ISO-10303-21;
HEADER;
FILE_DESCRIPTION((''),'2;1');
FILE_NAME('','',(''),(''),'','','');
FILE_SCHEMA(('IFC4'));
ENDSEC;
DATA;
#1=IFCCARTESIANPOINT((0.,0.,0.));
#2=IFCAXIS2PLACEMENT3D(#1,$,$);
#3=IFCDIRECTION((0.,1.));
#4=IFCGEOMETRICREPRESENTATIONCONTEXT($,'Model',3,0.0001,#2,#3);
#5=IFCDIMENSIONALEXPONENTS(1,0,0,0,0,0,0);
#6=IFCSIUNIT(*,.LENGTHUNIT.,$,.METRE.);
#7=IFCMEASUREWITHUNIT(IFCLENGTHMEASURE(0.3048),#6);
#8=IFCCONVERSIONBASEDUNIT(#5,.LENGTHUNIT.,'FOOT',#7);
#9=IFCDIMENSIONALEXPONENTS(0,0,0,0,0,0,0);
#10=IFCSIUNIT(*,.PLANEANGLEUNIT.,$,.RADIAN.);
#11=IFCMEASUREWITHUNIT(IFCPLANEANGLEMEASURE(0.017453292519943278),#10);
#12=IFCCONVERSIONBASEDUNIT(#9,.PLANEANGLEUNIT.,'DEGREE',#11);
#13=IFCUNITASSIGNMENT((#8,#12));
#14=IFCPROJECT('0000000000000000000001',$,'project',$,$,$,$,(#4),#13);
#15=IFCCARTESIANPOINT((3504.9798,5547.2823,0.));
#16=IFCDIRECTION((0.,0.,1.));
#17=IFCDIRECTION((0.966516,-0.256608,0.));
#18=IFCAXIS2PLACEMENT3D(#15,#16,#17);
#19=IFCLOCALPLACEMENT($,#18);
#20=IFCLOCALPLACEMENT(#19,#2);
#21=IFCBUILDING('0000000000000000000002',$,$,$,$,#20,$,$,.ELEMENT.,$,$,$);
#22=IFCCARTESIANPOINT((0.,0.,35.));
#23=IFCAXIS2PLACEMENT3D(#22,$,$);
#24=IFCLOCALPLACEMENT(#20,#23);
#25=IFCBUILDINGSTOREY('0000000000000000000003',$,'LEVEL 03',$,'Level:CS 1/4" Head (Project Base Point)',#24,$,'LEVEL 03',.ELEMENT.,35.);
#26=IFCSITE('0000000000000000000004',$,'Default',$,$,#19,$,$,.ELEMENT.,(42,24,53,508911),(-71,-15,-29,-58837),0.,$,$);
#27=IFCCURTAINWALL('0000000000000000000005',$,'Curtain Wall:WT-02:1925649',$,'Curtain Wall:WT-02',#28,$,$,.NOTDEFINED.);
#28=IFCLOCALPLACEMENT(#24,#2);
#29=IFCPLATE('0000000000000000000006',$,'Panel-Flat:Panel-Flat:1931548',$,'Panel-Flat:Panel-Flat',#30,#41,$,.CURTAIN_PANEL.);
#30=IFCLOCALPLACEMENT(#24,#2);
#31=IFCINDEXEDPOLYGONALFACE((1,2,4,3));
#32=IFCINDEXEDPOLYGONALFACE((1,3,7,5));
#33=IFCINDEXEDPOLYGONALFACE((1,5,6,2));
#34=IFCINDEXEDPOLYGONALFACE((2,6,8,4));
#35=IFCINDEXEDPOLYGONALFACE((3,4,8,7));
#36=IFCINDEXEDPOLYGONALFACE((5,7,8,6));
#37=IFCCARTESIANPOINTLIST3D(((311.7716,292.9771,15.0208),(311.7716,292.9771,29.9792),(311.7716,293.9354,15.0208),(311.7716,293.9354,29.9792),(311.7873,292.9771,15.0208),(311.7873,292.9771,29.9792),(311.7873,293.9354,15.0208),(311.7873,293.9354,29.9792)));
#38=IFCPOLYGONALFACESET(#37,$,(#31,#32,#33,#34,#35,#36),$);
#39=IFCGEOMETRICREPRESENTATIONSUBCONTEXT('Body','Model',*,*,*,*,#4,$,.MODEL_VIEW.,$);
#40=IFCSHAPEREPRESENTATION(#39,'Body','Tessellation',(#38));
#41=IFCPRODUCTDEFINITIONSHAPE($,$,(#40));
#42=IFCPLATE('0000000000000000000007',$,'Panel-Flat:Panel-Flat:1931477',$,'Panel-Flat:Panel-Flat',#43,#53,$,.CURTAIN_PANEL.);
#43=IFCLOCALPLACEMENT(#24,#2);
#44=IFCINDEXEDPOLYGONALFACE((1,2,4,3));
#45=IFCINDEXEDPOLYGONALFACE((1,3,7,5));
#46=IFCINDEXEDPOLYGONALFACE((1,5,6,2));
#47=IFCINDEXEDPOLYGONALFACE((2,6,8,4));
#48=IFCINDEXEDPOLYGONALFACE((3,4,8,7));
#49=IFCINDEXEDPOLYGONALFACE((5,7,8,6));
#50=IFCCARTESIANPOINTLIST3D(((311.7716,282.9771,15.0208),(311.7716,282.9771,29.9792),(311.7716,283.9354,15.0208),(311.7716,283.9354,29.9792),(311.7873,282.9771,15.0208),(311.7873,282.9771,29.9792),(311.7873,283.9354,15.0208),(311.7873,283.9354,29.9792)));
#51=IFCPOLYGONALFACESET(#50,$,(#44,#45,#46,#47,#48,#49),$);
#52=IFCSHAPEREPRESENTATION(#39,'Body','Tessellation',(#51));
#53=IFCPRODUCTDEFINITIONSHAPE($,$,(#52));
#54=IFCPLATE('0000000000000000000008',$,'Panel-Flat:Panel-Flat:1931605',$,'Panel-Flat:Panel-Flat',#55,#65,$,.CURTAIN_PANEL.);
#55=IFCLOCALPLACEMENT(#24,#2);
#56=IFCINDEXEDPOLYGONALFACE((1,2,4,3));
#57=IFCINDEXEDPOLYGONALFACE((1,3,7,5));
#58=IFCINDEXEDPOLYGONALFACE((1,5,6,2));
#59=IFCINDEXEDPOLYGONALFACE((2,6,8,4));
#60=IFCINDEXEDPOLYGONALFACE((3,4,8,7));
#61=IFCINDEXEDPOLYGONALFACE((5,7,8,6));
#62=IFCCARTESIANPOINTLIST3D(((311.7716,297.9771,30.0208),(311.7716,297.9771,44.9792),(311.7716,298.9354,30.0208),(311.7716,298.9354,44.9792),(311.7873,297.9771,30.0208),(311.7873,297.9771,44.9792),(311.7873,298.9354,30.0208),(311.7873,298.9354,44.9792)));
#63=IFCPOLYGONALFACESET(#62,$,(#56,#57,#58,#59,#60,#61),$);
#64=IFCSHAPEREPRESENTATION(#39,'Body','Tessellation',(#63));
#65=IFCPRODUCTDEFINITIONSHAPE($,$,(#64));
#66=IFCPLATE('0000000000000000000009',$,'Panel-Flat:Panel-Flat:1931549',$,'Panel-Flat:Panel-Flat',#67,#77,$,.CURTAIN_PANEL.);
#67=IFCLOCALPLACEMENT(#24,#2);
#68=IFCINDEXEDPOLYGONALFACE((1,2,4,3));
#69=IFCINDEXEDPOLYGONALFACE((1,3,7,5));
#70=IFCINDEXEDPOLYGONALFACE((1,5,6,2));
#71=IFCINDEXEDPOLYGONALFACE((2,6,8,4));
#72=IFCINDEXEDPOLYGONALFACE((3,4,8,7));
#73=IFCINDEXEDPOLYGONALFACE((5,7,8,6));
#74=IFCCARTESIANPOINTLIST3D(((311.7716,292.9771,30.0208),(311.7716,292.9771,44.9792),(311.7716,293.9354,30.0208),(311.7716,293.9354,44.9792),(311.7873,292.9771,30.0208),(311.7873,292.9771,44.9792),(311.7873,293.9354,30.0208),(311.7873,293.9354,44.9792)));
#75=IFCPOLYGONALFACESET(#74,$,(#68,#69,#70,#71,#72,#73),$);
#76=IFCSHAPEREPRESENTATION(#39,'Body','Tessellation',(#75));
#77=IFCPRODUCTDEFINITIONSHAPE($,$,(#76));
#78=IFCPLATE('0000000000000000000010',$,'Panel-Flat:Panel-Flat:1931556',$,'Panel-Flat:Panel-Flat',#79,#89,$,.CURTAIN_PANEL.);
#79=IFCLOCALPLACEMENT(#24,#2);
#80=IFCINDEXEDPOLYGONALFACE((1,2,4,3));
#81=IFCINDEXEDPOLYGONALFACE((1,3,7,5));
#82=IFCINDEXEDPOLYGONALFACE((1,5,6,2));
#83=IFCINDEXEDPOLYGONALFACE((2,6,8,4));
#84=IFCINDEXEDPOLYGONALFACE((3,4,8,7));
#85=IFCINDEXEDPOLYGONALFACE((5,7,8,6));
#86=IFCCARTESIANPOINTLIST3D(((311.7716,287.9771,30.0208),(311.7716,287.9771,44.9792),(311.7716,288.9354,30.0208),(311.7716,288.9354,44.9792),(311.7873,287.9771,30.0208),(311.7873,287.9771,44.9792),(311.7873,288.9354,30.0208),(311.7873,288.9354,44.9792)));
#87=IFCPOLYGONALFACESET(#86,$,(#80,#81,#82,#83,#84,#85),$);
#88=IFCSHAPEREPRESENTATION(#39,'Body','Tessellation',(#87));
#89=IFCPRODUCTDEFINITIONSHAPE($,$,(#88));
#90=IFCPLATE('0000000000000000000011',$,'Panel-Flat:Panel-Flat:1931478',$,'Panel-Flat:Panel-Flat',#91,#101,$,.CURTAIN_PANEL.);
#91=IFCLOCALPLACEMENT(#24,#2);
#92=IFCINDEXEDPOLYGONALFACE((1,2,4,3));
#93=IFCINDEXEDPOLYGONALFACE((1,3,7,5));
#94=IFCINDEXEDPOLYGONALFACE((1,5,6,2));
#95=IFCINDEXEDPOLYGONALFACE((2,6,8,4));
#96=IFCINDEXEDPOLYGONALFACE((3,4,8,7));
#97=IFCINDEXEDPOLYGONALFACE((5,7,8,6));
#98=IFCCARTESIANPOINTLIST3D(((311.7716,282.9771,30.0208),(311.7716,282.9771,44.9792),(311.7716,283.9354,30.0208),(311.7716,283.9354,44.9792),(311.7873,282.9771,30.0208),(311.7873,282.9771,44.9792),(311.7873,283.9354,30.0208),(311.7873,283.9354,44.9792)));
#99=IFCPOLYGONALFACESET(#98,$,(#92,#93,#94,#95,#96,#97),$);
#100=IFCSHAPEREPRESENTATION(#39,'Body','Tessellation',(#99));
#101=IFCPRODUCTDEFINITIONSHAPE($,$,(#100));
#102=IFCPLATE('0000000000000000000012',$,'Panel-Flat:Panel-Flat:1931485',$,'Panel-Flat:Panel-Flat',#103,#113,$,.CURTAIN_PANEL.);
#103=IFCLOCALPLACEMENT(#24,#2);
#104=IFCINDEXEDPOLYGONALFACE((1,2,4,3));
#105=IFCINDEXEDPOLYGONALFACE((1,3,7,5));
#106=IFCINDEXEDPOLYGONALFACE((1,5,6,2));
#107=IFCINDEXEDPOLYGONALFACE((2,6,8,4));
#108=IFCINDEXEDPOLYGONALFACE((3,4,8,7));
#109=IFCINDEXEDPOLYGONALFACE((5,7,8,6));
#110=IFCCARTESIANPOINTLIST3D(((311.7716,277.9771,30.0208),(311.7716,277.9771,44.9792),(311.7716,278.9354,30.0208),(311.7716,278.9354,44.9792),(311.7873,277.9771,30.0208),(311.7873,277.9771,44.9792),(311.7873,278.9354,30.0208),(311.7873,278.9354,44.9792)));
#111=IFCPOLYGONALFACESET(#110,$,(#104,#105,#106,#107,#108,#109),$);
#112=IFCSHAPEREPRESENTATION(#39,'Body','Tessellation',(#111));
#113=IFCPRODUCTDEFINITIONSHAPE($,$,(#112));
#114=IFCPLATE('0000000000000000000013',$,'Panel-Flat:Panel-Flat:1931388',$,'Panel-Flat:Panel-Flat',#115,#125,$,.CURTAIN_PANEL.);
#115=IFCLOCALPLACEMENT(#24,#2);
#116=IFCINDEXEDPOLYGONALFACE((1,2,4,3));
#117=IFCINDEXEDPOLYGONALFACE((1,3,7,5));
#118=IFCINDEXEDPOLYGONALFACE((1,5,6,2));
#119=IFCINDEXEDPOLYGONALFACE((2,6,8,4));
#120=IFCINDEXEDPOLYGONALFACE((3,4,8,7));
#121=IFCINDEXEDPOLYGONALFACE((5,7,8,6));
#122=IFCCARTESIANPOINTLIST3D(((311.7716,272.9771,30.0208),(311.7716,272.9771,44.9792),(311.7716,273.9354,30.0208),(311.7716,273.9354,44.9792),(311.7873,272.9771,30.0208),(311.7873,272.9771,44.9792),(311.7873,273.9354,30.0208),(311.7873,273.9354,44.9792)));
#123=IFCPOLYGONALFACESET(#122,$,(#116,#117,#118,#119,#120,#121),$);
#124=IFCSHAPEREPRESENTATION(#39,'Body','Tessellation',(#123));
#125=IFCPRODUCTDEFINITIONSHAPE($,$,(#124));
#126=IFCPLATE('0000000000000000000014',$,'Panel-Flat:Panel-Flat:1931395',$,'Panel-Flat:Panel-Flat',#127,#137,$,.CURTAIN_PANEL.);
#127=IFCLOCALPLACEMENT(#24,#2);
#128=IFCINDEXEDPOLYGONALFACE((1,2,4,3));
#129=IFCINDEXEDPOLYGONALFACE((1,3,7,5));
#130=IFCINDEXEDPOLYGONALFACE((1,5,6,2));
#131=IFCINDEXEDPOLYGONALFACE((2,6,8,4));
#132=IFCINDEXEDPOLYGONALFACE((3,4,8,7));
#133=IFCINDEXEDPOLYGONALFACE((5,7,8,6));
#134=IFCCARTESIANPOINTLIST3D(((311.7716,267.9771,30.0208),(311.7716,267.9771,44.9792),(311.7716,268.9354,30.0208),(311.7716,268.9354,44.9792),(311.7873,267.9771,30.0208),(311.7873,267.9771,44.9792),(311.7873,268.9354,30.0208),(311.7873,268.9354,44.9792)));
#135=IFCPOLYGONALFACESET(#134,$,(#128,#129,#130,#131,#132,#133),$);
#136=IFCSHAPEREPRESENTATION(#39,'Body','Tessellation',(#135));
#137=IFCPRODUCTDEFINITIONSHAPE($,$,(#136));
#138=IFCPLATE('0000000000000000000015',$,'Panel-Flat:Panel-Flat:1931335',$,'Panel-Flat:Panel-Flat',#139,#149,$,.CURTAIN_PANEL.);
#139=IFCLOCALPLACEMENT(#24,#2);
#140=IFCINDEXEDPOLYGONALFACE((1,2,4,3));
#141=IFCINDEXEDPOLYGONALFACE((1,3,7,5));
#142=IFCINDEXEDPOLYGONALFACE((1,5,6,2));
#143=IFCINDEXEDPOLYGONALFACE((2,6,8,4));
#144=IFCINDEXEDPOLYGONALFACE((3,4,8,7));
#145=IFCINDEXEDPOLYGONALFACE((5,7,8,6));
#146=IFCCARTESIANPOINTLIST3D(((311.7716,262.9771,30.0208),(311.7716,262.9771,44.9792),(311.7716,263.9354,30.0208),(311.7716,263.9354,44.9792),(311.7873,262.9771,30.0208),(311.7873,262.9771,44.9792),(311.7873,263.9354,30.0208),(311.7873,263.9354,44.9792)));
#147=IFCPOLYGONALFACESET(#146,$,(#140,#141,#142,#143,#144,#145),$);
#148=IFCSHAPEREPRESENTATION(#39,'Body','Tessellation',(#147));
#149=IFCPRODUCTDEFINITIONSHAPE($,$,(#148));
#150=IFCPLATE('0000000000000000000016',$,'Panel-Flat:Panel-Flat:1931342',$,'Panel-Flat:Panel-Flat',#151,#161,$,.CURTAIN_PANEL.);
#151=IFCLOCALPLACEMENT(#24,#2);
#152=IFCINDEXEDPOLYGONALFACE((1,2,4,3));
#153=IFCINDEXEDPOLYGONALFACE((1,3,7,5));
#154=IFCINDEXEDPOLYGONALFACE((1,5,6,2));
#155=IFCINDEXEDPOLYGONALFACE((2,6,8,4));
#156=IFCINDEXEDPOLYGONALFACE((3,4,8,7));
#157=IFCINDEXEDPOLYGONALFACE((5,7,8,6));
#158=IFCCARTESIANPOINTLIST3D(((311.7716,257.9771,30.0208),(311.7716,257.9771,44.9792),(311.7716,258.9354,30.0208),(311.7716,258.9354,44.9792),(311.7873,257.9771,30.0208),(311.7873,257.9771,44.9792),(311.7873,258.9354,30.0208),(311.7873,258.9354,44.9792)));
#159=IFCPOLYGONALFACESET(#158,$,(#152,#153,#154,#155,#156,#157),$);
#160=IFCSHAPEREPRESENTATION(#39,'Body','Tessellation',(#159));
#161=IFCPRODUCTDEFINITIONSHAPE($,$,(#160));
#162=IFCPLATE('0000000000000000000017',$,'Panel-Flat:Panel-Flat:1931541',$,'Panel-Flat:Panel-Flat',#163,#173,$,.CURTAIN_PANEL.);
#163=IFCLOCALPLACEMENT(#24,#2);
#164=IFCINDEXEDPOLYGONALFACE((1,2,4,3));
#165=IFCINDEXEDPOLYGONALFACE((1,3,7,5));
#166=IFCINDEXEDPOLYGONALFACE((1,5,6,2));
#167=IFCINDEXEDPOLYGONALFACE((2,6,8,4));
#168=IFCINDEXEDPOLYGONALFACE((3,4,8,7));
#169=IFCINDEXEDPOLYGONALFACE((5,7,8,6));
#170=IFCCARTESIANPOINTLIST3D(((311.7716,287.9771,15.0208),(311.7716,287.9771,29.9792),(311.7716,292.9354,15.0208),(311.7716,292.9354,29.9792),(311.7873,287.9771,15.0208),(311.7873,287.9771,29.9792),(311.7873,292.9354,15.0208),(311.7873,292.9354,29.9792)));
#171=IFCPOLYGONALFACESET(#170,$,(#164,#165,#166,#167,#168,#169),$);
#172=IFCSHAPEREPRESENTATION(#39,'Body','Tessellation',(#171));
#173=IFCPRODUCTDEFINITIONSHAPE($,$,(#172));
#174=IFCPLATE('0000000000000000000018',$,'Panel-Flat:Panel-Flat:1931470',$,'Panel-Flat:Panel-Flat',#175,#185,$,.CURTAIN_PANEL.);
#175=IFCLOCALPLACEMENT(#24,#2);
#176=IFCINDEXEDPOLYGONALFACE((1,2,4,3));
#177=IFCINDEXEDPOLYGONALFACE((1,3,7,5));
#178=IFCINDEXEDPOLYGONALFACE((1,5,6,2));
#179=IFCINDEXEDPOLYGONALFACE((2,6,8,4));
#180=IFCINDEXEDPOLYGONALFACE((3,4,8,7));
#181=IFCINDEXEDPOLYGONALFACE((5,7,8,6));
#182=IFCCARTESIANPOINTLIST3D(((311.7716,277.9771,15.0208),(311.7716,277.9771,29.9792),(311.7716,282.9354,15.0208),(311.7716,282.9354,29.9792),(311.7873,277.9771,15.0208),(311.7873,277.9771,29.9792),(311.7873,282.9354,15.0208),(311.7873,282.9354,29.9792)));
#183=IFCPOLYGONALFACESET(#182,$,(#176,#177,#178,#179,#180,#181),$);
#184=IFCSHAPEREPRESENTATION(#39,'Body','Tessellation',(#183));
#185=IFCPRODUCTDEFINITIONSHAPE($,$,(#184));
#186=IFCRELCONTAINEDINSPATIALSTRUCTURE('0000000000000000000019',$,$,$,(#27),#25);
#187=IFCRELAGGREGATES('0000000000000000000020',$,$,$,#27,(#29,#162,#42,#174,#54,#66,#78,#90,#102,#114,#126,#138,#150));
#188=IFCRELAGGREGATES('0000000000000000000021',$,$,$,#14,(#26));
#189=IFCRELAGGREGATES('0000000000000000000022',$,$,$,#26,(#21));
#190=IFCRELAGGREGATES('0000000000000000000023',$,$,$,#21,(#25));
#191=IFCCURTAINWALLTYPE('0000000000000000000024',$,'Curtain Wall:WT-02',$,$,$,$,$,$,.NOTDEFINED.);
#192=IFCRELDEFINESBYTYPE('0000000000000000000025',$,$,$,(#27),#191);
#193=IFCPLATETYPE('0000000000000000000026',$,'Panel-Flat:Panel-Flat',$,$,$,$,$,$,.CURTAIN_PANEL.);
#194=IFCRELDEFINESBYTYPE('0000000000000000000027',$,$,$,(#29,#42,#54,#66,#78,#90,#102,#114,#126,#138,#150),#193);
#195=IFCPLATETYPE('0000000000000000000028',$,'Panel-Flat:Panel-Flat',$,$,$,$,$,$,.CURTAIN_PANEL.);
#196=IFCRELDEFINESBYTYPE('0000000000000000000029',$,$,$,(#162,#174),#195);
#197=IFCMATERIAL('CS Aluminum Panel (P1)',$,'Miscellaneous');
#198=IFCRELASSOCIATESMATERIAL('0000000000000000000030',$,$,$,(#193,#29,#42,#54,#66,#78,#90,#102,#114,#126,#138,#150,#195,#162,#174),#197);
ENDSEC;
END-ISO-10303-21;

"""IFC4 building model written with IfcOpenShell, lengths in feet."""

from ifc_helpers import new_model, entity, si_unit, converted_unit, direction, frame, origin, place, context, subcontext, project, spatial, indexed_curve, outline, extrude, source, transform, mapped, material, type_object, type_shapes, element, aggregate, save


model = new_model("IFC4")

# Units and contexts
model_context = context("Model", 3, precision=0.0001, world=origin(), true_north=direction((0.0, 1.0)))
body_context = subcontext(model_context, "Body", "Model", "MODEL_VIEW")
ifc_project = project(units=[converted_unit("LENGTHUNIT", "FOOT", entity("IfcLengthMeasure", 0.3048), si_unit("LENGTHUNIT", "METRE"), dimensions=[1, 0, 0, 0, 0, 0, 0]), converted_unit("PLANEANGLEUNIT", "DEGREE", entity("IfcPlaneAngleMeasure", 0.017453292519943278), si_unit("PLANEANGLEUNIT", "RADIAN"), dimensions=[0, 0, 0, 0, 0, 0, 0])], contexts=[model_context])

# Site, building, storey
site_placement = place(None, frame((3504.9798, 5547.2823, 0.0), z_axis=(0.0, 0.0, 1.0), x_axis=(0.966516, -0.256608, 0.0)))
site = spatial("IfcSite", under=ifc_project, at=site_placement, Name="Default", CompositionType="ELEMENT", RefLatitude=(42, 24, 53, 508911), RefLongitude=(-71, -15, -29, -58837), RefElevation=0.0)
building_placement = place(site_placement, origin())
building = spatial("IfcBuilding", under=site, at=building_placement, CompositionType="ELEMENT")
storey_placement = place(building_placement, frame((0.0, 0.0, 35.0)))
storey = spatial("IfcBuildingStorey", under=building, at=storey_placement, Name="LEVEL 03", ObjectType="Level:CS 1/4\" Head (Project Base Point)", LongName="LEVEL 03", CompositionType="ELEMENT", Elevation=35.0)

# Curtain wall, plates
curtain_wall_type = type_object("IfcCurtainWallType", Name="Curtain Wall:WT-02", PredefinedType="NOTDEFINED")
curtain_wall_placement = place(storey_placement, frame((0.0, 0.0, -35.0)))
curtain_wall = element("IfcCurtainWall", 1, at=curtain_wall_placement, inside=storey, type_object=curtain_wall_type, Name="Curtain Wall:WT-02:1925649", ObjectType="Curtain Wall:WT-02", PredefinedType="NOTDEFINED")
ifc_material = material(Name="CS Aluminum Panel (P1)", Category="Miscellaneous")
plate_type_1 = type_object("IfcPlateType", Name="Panel-Flat:Panel-Flat", PredefinedType="CURTAIN_PANEL", material=ifc_material)
shared_shape_1 = source(origin(), body_context, "Body", "SweptSolid", [
    extrude(outline(indexed_curve([(-0.0078, -0.4792), (0.0078, -0.4792), (0.0078, 0.4792), (-0.0078, 0.4792), (-0.0078, -0.4792)], self_intersect=False)), frame((0.4792, 0.0078, 0.0), z_axis=(0.0, 0.0, 1.0), x_axis=(0.0, -1.0, 0.0)), (0.0, 0.0, 1.0), 14.9583),
])
type_shapes(plate_type_1, [shared_shape_1])
plate_1_placement = place(curtain_wall_placement, frame((311.7716, 293.9354, 50.0208), z_axis=(0.0, 0.0, 1.0), x_axis=(0.0, -1.0, 0.0)))
plate_1 = element("IfcPlate", 2, at=plate_1_placement, type_object=plate_type_1, material=ifc_material, Name="Panel-Flat:Panel-Flat:1931548", ObjectType="Panel-Flat:Panel-Flat", PredefinedType="CURTAIN_PANEL", context=body_context, shape_type="MappedRepresentation", body=[
    mapped(shared_shape_1, transform((0.0, 0.0, 0.0), scale=1.0)),
])
plate_2_placement = place(curtain_wall_placement, frame((311.7716, 283.9354, 50.0208), z_axis=(0.0, 0.0, 1.0), x_axis=(0.0, -1.0, 0.0)))
plate_2 = element("IfcPlate", 3, at=plate_2_placement, type_object=plate_type_1, material=ifc_material, Name="Panel-Flat:Panel-Flat:1931477", ObjectType="Panel-Flat:Panel-Flat", PredefinedType="CURTAIN_PANEL", context=body_context, shape_type="MappedRepresentation", body=[
    mapped(shared_shape_1, transform((0.0, 0.0, 0.0), scale=1.0)),
])
plate_3_placement = place(curtain_wall_placement, frame((311.7716, 298.9354, 65.0208), z_axis=(0.0, 0.0, 1.0), x_axis=(0.0, -1.0, 0.0)))
plate_3 = element("IfcPlate", 4, at=plate_3_placement, type_object=plate_type_1, material=ifc_material, Name="Panel-Flat:Panel-Flat:1931605", ObjectType="Panel-Flat:Panel-Flat", PredefinedType="CURTAIN_PANEL", context=body_context, shape_type="MappedRepresentation", body=[
    mapped(shared_shape_1, transform((0.0, 0.0, 0.0), scale=1.0)),
])
plate_4_placement = place(curtain_wall_placement, frame((311.7716, 293.9354, 65.0208), z_axis=(0.0, 0.0, 1.0), x_axis=(0.0, -1.0, 0.0)))
plate_4 = element("IfcPlate", 5, at=plate_4_placement, type_object=plate_type_1, material=ifc_material, Name="Panel-Flat:Panel-Flat:1931549", ObjectType="Panel-Flat:Panel-Flat", PredefinedType="CURTAIN_PANEL", context=body_context, shape_type="MappedRepresentation", body=[
    mapped(shared_shape_1, transform((0.0, 0.0, 0.0), scale=1.0)),
])
plate_5_placement = place(curtain_wall_placement, frame((311.7716, 288.9354, 65.0208), z_axis=(0.0, 0.0, 1.0), x_axis=(0.0, -1.0, 0.0)))
plate_5 = element("IfcPlate", 6, at=plate_5_placement, type_object=plate_type_1, material=ifc_material, Name="Panel-Flat:Panel-Flat:1931556", ObjectType="Panel-Flat:Panel-Flat", PredefinedType="CURTAIN_PANEL", context=body_context, shape_type="MappedRepresentation", body=[
    mapped(shared_shape_1, transform((0.0, 0.0, 0.0), scale=1.0)),
])
plate_6_placement = place(curtain_wall_placement, frame((311.7716, 283.9354, 65.0208), z_axis=(0.0, 0.0, 1.0), x_axis=(0.0, -1.0, 0.0)))
plate_6 = element("IfcPlate", 7, at=plate_6_placement, type_object=plate_type_1, material=ifc_material, Name="Panel-Flat:Panel-Flat:1931478", ObjectType="Panel-Flat:Panel-Flat", PredefinedType="CURTAIN_PANEL", context=body_context, shape_type="MappedRepresentation", body=[
    mapped(shared_shape_1, transform((0.0, 0.0, 0.0), scale=1.0)),
])
plate_7_placement = place(curtain_wall_placement, frame((311.7716, 278.9354, 65.0208), z_axis=(0.0, 0.0, 1.0), x_axis=(0.0, -1.0, 0.0)))
plate_7 = element("IfcPlate", 8, at=plate_7_placement, type_object=plate_type_1, material=ifc_material, Name="Panel-Flat:Panel-Flat:1931485", ObjectType="Panel-Flat:Panel-Flat", PredefinedType="CURTAIN_PANEL", context=body_context, shape_type="MappedRepresentation", body=[
    mapped(shared_shape_1, transform((0.0, 0.0, 0.0), scale=1.0)),
])
plate_8_placement = place(curtain_wall_placement, frame((311.7716, 273.9354, 65.0208), z_axis=(0.0, 0.0, 1.0), x_axis=(0.0, -1.0, 0.0)))
plate_8 = element("IfcPlate", 9, at=plate_8_placement, type_object=plate_type_1, material=ifc_material, Name="Panel-Flat:Panel-Flat:1931388", ObjectType="Panel-Flat:Panel-Flat", PredefinedType="CURTAIN_PANEL", context=body_context, shape_type="MappedRepresentation", body=[
    mapped(shared_shape_1, transform((0.0, 0.0, 0.0), scale=1.0)),
])
plate_9_placement = place(curtain_wall_placement, frame((311.7716, 268.9354, 65.0208), z_axis=(0.0, 0.0, 1.0), x_axis=(0.0, -1.0, 0.0)))
plate_9 = element("IfcPlate", 10, at=plate_9_placement, type_object=plate_type_1, material=ifc_material, Name="Panel-Flat:Panel-Flat:1931395", ObjectType="Panel-Flat:Panel-Flat", PredefinedType="CURTAIN_PANEL", context=body_context, shape_type="MappedRepresentation", body=[
    mapped(shared_shape_1, transform((0.0, 0.0, 0.0), scale=1.0)),
])
plate_10_placement = place(curtain_wall_placement, frame((311.7716, 263.9354, 65.0208), z_axis=(0.0, 0.0, 1.0), x_axis=(0.0, -1.0, 0.0)))
plate_10 = element("IfcPlate", 11, at=plate_10_placement, type_object=plate_type_1, material=ifc_material, Name="Panel-Flat:Panel-Flat:1931335", ObjectType="Panel-Flat:Panel-Flat", PredefinedType="CURTAIN_PANEL", context=body_context, shape_type="MappedRepresentation", body=[
    mapped(shared_shape_1, transform((0.0, 0.0, 0.0), scale=1.0)),
])
plate_11_placement = place(curtain_wall_placement, frame((311.7716, 258.9354, 65.0208), z_axis=(0.0, 0.0, 1.0), x_axis=(0.0, -1.0, 0.0)))
plate_11 = element("IfcPlate", 12, at=plate_11_placement, type_object=plate_type_1, material=ifc_material, Name="Panel-Flat:Panel-Flat:1931342", ObjectType="Panel-Flat:Panel-Flat", PredefinedType="CURTAIN_PANEL", context=body_context, shape_type="MappedRepresentation", body=[
    mapped(shared_shape_1, transform((0.0, 0.0, 0.0), scale=1.0)),
])
plate_type_2 = type_object("IfcPlateType", Name="Panel-Flat:Panel-Flat", PredefinedType="CURTAIN_PANEL", material=ifc_material)
shared_shape_2 = source(origin(), body_context, "Body", "SweptSolid", [
    extrude(outline(indexed_curve([(-0.0078, -2.4792), (0.0078, -2.4792), (0.0078, 2.4792), (-0.0078, 2.4792), (-0.0078, -2.4792)], self_intersect=False)), frame((2.4792, 0.0078, 0.0), z_axis=(0.0, 0.0, 1.0), x_axis=(0.0, -1.0, 0.0)), (0.0, 0.0, 1.0), 14.9583),
])
type_shapes(plate_type_2, [shared_shape_2])
plate_12_placement = place(curtain_wall_placement, frame((311.7716, 292.9354, 50.0208), z_axis=(0.0, 0.0, 1.0), x_axis=(0.0, -1.0, 0.0)))
plate_12 = element("IfcPlate", 13, at=plate_12_placement, type_object=plate_type_2, material=ifc_material, Name="Panel-Flat:Panel-Flat:1931541", ObjectType="Panel-Flat:Panel-Flat", PredefinedType="CURTAIN_PANEL", context=body_context, shape_type="MappedRepresentation", body=[
    mapped(shared_shape_2, transform((0.0, 0.0, 0.0), scale=1.0)),
])
plate_13_placement = place(curtain_wall_placement, frame((311.7716, 282.9354, 50.0208), z_axis=(0.0, 0.0, 1.0), x_axis=(0.0, -1.0, 0.0)))
plate_13 = element("IfcPlate", 14, at=plate_13_placement, type_object=plate_type_2, material=ifc_material, Name="Panel-Flat:Panel-Flat:1931470", ObjectType="Panel-Flat:Panel-Flat", PredefinedType="CURTAIN_PANEL", context=body_context, shape_type="MappedRepresentation", body=[
    mapped(shared_shape_2, transform((0.0, 0.0, 0.0), scale=1.0)),
])
aggregate(curtain_wall, [plate_1, plate_12, plate_2, plate_13, plate_3, plate_4, plate_5, plate_6, plate_7, plate_8, plate_9, plate_10, plate_11])

save(model, "model.ifc")
